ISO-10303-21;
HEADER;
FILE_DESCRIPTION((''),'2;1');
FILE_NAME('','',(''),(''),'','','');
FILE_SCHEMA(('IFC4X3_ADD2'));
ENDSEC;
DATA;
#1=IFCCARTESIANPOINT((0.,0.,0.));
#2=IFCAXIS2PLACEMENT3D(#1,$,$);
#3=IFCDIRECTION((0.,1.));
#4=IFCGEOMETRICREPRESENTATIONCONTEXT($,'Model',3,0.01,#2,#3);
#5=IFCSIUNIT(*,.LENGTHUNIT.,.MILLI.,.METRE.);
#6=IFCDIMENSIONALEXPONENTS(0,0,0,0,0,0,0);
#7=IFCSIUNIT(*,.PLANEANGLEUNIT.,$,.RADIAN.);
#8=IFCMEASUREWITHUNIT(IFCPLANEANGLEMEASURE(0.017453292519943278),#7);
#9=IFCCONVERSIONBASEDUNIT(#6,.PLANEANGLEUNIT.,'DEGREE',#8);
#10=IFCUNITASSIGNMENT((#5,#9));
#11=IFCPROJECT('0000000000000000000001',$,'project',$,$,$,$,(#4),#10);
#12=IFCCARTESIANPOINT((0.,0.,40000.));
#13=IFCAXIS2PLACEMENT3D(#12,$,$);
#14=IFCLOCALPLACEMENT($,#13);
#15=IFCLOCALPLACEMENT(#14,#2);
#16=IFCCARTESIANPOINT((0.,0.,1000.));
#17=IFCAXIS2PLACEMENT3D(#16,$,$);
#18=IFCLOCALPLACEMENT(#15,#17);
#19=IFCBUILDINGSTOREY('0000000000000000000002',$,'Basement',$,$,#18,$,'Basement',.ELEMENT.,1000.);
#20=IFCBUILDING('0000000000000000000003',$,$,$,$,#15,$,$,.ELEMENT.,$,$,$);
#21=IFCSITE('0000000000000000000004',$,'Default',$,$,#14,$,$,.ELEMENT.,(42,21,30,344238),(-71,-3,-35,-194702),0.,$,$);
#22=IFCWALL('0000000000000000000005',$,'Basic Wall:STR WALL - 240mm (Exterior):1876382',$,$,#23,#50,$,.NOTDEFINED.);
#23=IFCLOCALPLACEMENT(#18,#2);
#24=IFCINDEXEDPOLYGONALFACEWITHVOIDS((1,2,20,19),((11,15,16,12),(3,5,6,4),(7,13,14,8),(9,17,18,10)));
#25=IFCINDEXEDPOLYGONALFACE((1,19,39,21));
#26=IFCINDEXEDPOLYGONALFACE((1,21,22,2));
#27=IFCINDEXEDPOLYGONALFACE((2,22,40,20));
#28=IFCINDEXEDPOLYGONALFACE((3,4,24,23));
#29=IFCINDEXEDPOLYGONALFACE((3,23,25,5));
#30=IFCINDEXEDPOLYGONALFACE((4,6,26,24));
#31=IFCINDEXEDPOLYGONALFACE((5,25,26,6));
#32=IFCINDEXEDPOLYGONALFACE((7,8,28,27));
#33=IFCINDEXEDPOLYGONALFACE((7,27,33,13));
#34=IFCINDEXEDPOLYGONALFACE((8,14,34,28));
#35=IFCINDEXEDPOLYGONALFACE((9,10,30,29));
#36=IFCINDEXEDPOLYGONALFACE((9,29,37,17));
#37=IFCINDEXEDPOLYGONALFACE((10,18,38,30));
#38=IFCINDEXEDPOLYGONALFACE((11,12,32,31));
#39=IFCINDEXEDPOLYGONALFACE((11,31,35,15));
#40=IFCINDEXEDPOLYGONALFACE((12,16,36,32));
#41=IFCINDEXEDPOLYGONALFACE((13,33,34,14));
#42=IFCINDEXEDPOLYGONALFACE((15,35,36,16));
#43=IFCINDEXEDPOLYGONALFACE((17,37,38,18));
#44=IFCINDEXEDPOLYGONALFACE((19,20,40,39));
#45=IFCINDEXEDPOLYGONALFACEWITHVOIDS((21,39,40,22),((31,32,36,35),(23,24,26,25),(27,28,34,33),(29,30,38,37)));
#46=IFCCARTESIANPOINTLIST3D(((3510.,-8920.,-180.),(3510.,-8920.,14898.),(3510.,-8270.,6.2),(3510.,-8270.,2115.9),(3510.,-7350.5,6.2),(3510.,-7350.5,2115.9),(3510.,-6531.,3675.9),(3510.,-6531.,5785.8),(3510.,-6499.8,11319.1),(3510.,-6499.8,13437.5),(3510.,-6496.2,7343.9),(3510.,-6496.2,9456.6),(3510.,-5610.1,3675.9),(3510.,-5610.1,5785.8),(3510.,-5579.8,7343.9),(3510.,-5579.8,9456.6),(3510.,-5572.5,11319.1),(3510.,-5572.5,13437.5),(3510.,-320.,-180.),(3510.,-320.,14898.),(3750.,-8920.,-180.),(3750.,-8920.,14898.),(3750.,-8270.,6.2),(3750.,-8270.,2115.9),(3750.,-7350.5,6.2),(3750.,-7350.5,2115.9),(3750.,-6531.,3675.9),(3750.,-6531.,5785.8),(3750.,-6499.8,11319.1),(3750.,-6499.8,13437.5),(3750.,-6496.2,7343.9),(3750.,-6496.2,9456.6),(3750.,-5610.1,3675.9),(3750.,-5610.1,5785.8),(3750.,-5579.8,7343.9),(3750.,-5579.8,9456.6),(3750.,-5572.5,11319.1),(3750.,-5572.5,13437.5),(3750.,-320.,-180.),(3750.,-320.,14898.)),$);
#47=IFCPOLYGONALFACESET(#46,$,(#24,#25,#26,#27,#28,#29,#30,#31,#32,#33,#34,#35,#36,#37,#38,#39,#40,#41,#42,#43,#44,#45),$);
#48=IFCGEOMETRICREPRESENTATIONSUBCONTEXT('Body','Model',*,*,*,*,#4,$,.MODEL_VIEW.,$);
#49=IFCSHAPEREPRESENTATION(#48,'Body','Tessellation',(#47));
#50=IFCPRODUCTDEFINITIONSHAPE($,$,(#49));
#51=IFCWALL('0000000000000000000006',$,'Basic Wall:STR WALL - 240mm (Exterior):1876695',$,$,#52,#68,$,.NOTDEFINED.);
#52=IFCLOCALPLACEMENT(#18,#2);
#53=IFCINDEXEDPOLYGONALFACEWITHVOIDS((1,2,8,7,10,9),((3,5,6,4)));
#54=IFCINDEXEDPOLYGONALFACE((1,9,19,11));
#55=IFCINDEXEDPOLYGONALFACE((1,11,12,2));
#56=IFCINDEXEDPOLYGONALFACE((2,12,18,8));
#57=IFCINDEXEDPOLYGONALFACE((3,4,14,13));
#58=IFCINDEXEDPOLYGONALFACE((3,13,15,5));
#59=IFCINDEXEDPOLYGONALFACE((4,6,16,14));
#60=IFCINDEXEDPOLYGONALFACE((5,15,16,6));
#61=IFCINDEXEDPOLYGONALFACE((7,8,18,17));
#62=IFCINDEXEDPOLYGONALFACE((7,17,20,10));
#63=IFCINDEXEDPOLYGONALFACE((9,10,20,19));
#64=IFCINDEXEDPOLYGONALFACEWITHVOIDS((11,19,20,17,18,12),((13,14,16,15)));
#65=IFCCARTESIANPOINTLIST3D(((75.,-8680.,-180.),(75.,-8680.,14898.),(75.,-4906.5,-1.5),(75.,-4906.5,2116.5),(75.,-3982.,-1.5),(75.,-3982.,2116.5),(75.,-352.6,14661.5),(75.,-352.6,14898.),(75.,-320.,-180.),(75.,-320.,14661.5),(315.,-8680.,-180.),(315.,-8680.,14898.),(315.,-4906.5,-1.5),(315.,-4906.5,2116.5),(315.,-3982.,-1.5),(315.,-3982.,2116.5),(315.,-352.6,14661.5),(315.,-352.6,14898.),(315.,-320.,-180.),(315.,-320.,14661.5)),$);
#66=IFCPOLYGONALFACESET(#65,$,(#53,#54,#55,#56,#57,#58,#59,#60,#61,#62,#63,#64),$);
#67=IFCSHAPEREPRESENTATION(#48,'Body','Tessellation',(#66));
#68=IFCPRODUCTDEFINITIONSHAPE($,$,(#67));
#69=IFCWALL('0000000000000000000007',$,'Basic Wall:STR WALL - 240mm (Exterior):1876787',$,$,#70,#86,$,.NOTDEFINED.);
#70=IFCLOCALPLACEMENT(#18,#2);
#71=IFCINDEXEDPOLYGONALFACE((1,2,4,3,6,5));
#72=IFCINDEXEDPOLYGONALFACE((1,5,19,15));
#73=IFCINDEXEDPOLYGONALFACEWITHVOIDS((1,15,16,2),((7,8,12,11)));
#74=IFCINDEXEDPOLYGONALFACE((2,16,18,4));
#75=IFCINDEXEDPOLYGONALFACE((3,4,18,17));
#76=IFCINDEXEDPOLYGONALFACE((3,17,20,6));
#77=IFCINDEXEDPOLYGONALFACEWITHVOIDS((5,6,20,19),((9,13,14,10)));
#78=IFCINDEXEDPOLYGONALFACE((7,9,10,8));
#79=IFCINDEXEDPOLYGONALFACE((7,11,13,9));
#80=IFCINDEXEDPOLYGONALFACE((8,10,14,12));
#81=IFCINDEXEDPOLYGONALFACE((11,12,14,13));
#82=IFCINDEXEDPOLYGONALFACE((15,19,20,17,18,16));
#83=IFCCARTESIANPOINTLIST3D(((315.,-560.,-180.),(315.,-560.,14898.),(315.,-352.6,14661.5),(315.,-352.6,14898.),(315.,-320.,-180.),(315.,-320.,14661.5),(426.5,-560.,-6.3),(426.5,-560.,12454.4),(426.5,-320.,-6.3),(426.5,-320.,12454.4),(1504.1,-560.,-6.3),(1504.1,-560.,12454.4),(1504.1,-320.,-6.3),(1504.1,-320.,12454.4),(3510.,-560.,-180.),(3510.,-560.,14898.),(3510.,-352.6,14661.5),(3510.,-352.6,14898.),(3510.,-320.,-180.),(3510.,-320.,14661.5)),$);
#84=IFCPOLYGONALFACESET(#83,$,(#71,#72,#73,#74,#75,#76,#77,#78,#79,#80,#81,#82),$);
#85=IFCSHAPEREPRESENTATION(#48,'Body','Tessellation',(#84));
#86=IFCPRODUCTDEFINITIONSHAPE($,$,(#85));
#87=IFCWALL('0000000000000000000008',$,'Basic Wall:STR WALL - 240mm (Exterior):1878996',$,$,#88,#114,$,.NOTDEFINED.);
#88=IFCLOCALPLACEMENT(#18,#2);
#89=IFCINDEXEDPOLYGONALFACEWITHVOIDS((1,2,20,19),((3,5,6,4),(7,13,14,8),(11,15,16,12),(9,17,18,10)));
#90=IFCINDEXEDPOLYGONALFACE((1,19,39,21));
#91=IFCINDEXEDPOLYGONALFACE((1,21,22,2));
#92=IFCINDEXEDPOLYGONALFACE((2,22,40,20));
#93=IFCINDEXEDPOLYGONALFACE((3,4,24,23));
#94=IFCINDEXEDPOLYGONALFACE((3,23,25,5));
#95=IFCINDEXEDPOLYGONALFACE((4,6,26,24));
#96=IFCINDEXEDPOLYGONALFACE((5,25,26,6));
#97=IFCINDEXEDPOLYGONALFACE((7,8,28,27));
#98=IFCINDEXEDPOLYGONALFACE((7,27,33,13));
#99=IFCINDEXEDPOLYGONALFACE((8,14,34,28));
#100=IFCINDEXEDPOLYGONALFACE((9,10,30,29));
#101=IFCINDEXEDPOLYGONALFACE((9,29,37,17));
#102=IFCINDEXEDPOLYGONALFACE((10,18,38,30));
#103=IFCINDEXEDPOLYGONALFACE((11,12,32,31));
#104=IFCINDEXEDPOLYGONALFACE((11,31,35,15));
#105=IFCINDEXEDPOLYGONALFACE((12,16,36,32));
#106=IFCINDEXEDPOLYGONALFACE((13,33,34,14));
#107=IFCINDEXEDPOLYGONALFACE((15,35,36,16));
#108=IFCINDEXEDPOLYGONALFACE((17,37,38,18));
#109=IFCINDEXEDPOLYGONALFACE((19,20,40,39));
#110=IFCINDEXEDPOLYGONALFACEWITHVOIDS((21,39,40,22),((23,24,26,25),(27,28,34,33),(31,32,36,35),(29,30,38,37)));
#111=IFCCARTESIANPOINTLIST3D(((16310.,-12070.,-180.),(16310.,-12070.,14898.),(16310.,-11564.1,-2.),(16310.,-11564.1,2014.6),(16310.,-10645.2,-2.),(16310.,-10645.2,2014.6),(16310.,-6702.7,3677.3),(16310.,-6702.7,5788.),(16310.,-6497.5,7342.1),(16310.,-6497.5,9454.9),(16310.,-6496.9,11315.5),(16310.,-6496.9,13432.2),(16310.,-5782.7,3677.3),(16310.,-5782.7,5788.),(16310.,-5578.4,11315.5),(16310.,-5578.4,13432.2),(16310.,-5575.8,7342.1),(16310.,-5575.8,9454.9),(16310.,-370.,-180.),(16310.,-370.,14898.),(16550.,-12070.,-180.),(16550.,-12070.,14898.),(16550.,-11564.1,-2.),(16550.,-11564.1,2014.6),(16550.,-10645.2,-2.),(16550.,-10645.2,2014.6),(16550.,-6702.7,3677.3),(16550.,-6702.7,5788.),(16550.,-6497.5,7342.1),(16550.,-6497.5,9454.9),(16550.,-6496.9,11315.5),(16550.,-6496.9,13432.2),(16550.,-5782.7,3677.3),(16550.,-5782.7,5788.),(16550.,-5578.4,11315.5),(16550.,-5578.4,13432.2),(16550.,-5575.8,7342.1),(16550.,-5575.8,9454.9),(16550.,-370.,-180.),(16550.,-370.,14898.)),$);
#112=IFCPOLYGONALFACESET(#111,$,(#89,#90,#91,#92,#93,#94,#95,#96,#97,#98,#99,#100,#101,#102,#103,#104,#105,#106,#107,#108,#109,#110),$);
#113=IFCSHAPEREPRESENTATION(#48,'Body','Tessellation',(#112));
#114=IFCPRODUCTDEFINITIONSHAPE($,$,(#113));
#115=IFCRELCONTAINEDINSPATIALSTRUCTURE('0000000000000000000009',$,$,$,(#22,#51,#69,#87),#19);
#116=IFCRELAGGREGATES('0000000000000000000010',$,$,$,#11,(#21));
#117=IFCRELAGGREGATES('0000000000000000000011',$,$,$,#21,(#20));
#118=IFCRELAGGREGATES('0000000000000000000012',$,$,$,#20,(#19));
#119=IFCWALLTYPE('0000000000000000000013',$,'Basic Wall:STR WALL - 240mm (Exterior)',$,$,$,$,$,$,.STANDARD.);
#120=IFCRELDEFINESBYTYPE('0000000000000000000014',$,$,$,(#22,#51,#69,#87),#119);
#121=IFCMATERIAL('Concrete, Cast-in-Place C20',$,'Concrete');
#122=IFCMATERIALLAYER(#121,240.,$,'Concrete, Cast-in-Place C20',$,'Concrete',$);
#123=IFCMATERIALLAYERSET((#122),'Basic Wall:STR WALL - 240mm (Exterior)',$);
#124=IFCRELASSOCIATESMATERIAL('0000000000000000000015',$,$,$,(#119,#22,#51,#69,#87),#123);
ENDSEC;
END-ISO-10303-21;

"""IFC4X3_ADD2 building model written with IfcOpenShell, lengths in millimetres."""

from ifc_helpers import new_model, entity, si_unit, converted_unit, direction, frame, frame_2d, origin, origin_2d_with_axis, place, context, subcontext, project, spatial, polyline, rectangle, extrude, clip, bounded_halfspace, material, layer, layer_set, type_object, element, save


model = new_model("IFC4X3_ADD2")

# Units and contexts
model_context = context("Model", 3, precision=0.01, world=origin(), true_north=direction((0.0, 1.0)))
body_context = subcontext(model_context, "Body", "Model", "MODEL_VIEW")
ifc_project = project(units=[si_unit("LENGTHUNIT", "METRE", prefix="MILLI"), converted_unit("PLANEANGLEUNIT", "DEGREE", entity("IfcPlaneAngleMeasure", 0.017453292519943278), si_unit("PLANEANGLEUNIT", "RADIAN"), dimensions=[0, 0, 0, 0, 0, 0, 0])], contexts=[model_context])

# Site, building, storey
site_placement = place(None, frame((0.0, 0.0, 40000.0)))
site = spatial("IfcSite", under=ifc_project, at=site_placement, Name="Default", CompositionType="ELEMENT", RefLatitude=(42, 21, 30, 344238), RefLongitude=(-71, -3, -35, -194702), RefElevation=0.0)
building_placement = place(site_placement, origin())
building = spatial("IfcBuilding", under=site, at=building_placement, CompositionType="ELEMENT")
storey_placement = place(building_placement, frame((0.0, 0.0, 1000.0)))
storey = spatial("IfcBuildingStorey", under=building, at=storey_placement, Name="Basement", LongName="Basement", CompositionType="ELEMENT", Elevation=1000.0)

# Wall, openings
ifc_material_1 = material(Name="Concrete, Cast-in-Place C20", Category="Concrete")
ifc_layer = layer(ifc_material_1, 240.0, Name="Concrete, Cast-in-Place C20", Category="Concrete")
ifc_layer_set = layer_set([ifc_layer], Name="Basic Wall:STR WALL - 240mm (Exterior)")
wall_type = type_object("IfcWallType", Name="Basic Wall:STR WALL - 240mm (Exterior)", PredefinedType="STANDARD", material=ifc_layer_set)
wall_1_placement = place(storey_placement, frame((3630.0, -320.0, -180.0), z_axis=(0.0, 0.0, 1.0), x_axis=(0.0, -1.0, 0.0)))
wall_1 = element("IfcWall", 1, at=wall_1_placement, inside=storey, type_object=wall_type, material=ifc_layer_set, Name="Basic Wall:STR WALL - 240mm (Exterior):1876382", PredefinedType="NOTDEFINED", context=body_context, shape_type="SweptSolid", body=[
    extrude(rectangle(XDim=8600.0, YDim=240.0, at=frame_2d((4300.0, 0.0), x_axis=(-1.0, 0.0))), origin(), (0.0, 0.0, 1.0), 15078.0),
])
opening_1_placement = place(wall_1_placement, frame((6179.8, -120.0, 11499.1)))
element("IfcOpeningElement", 2, at=opening_1_placement, cuts=wall_1, PredefinedType="OPENING", context=body_context, shape_type="SweptSolid", body=[
    extrude(rectangle(XDim=2118.5, YDim=927.3, at=frame_2d((0.0, 0.0), x_axis=(1.0, 0.0))), frame((-463.7, 0.0, 1059.2), z_axis=(0.0, 1.0, 0.0), x_axis=(0.0, 0.0, -1.0)), (0.0, 0.0, 1.0), 240.0),
])
opening_2_placement = place(wall_1_placement, frame((6176.2, -120.0, 7523.9)))
element("IfcOpeningElement", 3, at=opening_2_placement, cuts=wall_1, PredefinedType="OPENING", context=body_context, shape_type="SweptSolid", body=[
    extrude(rectangle(XDim=2112.6, YDim=916.4, at=origin_2d_with_axis()), frame((-458.2, 0.0, 1056.3), z_axis=(0.0, 1.0, 0.0), x_axis=(0.0, 0.0, -1.0)), (0.0, 0.0, 1.0), 240.0),
])
opening_3_placement = place(wall_1_placement, frame((6211.0, -120.0, 3855.9)))
element("IfcOpeningElement", 4, at=opening_3_placement, cuts=wall_1, PredefinedType="OPENING", context=body_context, shape_type="SweptSolid", body=[
    extrude(rectangle(XDim=2109.8, YDim=920.9, at=frame_2d((0.0, 0.0), x_axis=(1.0, 0.0))), frame((-460.4, 0.0, 1054.9), z_axis=(0.0, 1.0, 0.0), x_axis=(0.0, 0.0, -1.0)), (0.0, 0.0, 1.0), 240.0),
])
opening_4_placement = place(wall_1_placement, frame((7950.0, -120.0, 186.2)))
element("IfcOpeningElement", 5, at=opening_4_placement, cuts=wall_1, PredefinedType="OPENING", context=body_context, shape_type="SweptSolid", body=[
    extrude(rectangle(XDim=2109.7, YDim=919.5, at=frame_2d((0.0, 0.0), x_axis=(1.0, 0.0))), frame((-459.8, 0.0, 1054.8), z_axis=(0.0, 1.0, 0.0), x_axis=(0.0, 0.0, -1.0)), (0.0, 0.0, 1.0), 240.0),
])

# Walls, openings
wall_2_placement = place(storey_placement, frame((195.0, -8680.0, -180.0), z_axis=(0.0, 0.0, 1.0), x_axis=(0.0, 1.0, 0.0)))
wall_2 = element("IfcWall", 6, at=wall_2_placement, inside=storey, type_object=wall_type, material=ifc_layer_set, Name="Basic Wall:STR WALL - 240mm (Exterior):1876695", PredefinedType="NOTDEFINED", context=body_context, shape_type="Clipping", body=[
    clip(clip(extrude(rectangle(XDim=8360.0, YDim=240.0, at=frame_2d((4180.0, 0.0), x_axis=(-1.0, 0.0))), origin(), (0.0, 0.0, 1.0), 15078.0), bounded_halfspace(frame((0.0, -120.0, 15078.0), z_axis=(0.0, 0.0, -1.0), x_axis=(0.0, -1.0, 0.0)), True, frame((0.0, -120.0, 15078.0)), polyline([(0.0, 0.0), (8120.0, 0.0), (8327.4, 0.0), (8327.4, 240.0), (0.0, 240.0), (0.0, 0.0)]))), bounded_halfspace(frame((8327.4, -120.0, 14841.5), z_axis=(0.0, 0.0, 1.0), x_axis=(0.0, 1.0, 0.0)), False, frame((8327.4, -120.0, 14841.5)), polyline([(0.0, 0.0), (32.6, 0.0), (32.6, 240.0), (0.0, 240.0), (0.0, 0.0)]))),
])
opening_5_placement = place(wall_2_placement, frame((3773.5, 120.0, 178.5)))
element("IfcOpeningElement", 7, at=opening_5_placement, cuts=wall_2, PredefinedType="OPENING", context=body_context, shape_type="SweptSolid", body=[
    extrude(rectangle(XDim=2118.0, YDim=924.5, at=frame_2d((0.0, 0.0), x_axis=(1.0, 0.0))), frame((462.3, -240.0, 1059.0), z_axis=(0.0, 1.0, 0.0), x_axis=(0.0, 0.0, -1.0)), (0.0, 0.0, 1.0), 240.0),
])
wall_3_placement = place(storey_placement, frame((315.0, -440.0, -180.0)))
wall_3 = element("IfcWall", 8, at=wall_3_placement, inside=storey, type_object=wall_type, material=ifc_layer_set, Name="Basic Wall:STR WALL - 240mm (Exterior):1876787", PredefinedType="NOTDEFINED", context=body_context, shape_type="Clipping", body=[
    clip(clip(extrude(rectangle(XDim=3195.0, YDim=240.0, at=frame_2d((1597.5, 0.0), x_axis=(-1.0, 0.0))), origin(), (0.0, 0.0, 1.0), 15078.0), bounded_halfspace(frame((0.0, -120.0, 15078.0), z_axis=(0.0, 0.0, -1.0), x_axis=(1.0, 0.0, 0.0)), True, frame((0.0, -120.0, 15078.0)), polyline([(0.0, 0.0), (3195.0, 0.0), (3195.0, 207.4), (0.0, 207.4), (0.0, 0.0)]))), bounded_halfspace(frame((3195.0, 87.4, 14841.5), z_axis=(0.0, 0.0, 1.0), x_axis=(0.0, 1.0, 0.0)), False, frame((3195.0, 87.4, 14841.5)), polyline([(0.0, 0.0), (0.0, 32.6), (-3195.0, 32.6), (-3195.0, 0.0), (0.0, 0.0)]))),
])
opening_6_placement = place(wall_3_placement, frame((111.5, -120.0, 173.7)))
element("IfcOpeningElement", 9, at=opening_6_placement, cuts=wall_3, PredefinedType="OPENING", context=body_context, shape_type="SweptSolid", body=[
    extrude(rectangle(XDim=12460.7, YDim=1077.6, at=frame_2d((0.0, 0.0), x_axis=(1.0, 0.0))), frame((538.8, 0.0, 6230.3), z_axis=(0.0, 1.0, 0.0), x_axis=(0.0, 0.0, -1.0)), (0.0, 0.0, 1.0), 240.0),
])

# Wall, openings
wall_4_placement = place(storey_placement, frame((16430.0, -370.0, -180.0), z_axis=(0.0, 0.0, 1.0), x_axis=(0.0, -1.0, 0.0)))
wall_4 = element("IfcWall", 10, at=wall_4_placement, inside=storey, type_object=wall_type, material=ifc_layer_set, Name="Basic Wall:STR WALL - 240mm (Exterior):1878996", PredefinedType="NOTDEFINED", context=body_context, shape_type="Clipping", body=[
    clip(clip(extrude(rectangle(XDim=11700.0, YDim=240.0, at=frame_2d((5850.0, 0.0), x_axis=(-1.0, 0.0))), origin(), (0.0, 0.0, 1.0), 15078.0), bounded_halfspace(frame((0.0, -120.0, 15078.0), z_axis=(0.0, 0.0, -1.0), x_axis=(0.0, 1.0, 0.0)), True, frame((0.0, -120.0, 15078.0)), polyline([(0.0, 0.0), (11700.0, 0.0), (11700.0, 116.7), (0.0, 116.7), (0.0, 0.0)]))), bounded_halfspace(frame((11700.0, -3.3, 15078.0), z_axis=(0.0, 0.0, -1.0), x_axis=(1.0, 0.0, 0.0)), True, frame((11700.0, -3.3, 15078.0)), polyline([(0.0, 0.0), (0.0, 123.3), (-11700.0, 123.3), (-11700.0, 0.0), (0.0, 0.0)]))),
])
opening_7_placement = place(wall_4_placement, frame((11194.1, -120.0, 178.0)))
element("IfcOpeningElement", 11, at=opening_7_placement, cuts=wall_4, PredefinedType="OPENING", context=body_context, shape_type="SweptSolid", body=[
    extrude(rectangle(XDim=2016.6, YDim=918.9, at=frame_2d((0.0, 0.0), x_axis=(1.0, 0.0))), frame((-459.5, 0.0, 1008.3), z_axis=(0.0, 1.0, 0.0), x_axis=(0.0, 0.0, -1.0)), (0.0, 0.0, 1.0), 240.0),
])
opening_8_placement = place(wall_4_placement, frame((6332.7, -120.0, 3857.3)))
element("IfcOpeningElement", 12, at=opening_8_placement, cuts=wall_4, PredefinedType="OPENING", context=body_context, shape_type="SweptSolid", body=[
    extrude(rectangle(XDim=2110.6, YDim=920.0, at=frame_2d((0.0, 0.0), x_axis=(1.0, 0.0))), frame((-460.0, 0.0, 1055.3), z_axis=(0.0, 1.0, 0.0), x_axis=(0.0, 0.0, -1.0)), (0.0, 0.0, 1.0), 240.0),
])
opening_9_placement = place(wall_4_placement, frame((6126.9, -120.0, 11495.5)))
element("IfcOpeningElement", 13, at=opening_9_placement, cuts=wall_4, PredefinedType="OPENING", context=body_context, shape_type="SweptSolid", body=[
    extrude(rectangle(XDim=2116.6, YDim=918.4, at=frame_2d((0.0, 0.0), x_axis=(1.0, 0.0))), frame((-459.2, 0.0, 1058.3), z_axis=(0.0, 1.0, 0.0), x_axis=(0.0, 0.0, -1.0)), (0.0, 0.0, 1.0), 240.0),
])
opening_10_placement = place(wall_4_placement, frame((6127.5, -120.0, 7522.1)))
element("IfcOpeningElement", 14, at=opening_10_placement, cuts=wall_4, PredefinedType="OPENING", context=body_context, shape_type="SweptSolid", body=[
    extrude(rectangle(XDim=2112.7, YDim=921.7, at=frame_2d((0.0, 0.0), x_axis=(1.0, 0.0))), frame((-460.8, 0.0, 1056.4), z_axis=(0.0, 1.0, 0.0), x_axis=(0.0, 0.0, -1.0)), (0.0, 0.0, 1.0), 240.0),
])

save(model, "model.ifc")
